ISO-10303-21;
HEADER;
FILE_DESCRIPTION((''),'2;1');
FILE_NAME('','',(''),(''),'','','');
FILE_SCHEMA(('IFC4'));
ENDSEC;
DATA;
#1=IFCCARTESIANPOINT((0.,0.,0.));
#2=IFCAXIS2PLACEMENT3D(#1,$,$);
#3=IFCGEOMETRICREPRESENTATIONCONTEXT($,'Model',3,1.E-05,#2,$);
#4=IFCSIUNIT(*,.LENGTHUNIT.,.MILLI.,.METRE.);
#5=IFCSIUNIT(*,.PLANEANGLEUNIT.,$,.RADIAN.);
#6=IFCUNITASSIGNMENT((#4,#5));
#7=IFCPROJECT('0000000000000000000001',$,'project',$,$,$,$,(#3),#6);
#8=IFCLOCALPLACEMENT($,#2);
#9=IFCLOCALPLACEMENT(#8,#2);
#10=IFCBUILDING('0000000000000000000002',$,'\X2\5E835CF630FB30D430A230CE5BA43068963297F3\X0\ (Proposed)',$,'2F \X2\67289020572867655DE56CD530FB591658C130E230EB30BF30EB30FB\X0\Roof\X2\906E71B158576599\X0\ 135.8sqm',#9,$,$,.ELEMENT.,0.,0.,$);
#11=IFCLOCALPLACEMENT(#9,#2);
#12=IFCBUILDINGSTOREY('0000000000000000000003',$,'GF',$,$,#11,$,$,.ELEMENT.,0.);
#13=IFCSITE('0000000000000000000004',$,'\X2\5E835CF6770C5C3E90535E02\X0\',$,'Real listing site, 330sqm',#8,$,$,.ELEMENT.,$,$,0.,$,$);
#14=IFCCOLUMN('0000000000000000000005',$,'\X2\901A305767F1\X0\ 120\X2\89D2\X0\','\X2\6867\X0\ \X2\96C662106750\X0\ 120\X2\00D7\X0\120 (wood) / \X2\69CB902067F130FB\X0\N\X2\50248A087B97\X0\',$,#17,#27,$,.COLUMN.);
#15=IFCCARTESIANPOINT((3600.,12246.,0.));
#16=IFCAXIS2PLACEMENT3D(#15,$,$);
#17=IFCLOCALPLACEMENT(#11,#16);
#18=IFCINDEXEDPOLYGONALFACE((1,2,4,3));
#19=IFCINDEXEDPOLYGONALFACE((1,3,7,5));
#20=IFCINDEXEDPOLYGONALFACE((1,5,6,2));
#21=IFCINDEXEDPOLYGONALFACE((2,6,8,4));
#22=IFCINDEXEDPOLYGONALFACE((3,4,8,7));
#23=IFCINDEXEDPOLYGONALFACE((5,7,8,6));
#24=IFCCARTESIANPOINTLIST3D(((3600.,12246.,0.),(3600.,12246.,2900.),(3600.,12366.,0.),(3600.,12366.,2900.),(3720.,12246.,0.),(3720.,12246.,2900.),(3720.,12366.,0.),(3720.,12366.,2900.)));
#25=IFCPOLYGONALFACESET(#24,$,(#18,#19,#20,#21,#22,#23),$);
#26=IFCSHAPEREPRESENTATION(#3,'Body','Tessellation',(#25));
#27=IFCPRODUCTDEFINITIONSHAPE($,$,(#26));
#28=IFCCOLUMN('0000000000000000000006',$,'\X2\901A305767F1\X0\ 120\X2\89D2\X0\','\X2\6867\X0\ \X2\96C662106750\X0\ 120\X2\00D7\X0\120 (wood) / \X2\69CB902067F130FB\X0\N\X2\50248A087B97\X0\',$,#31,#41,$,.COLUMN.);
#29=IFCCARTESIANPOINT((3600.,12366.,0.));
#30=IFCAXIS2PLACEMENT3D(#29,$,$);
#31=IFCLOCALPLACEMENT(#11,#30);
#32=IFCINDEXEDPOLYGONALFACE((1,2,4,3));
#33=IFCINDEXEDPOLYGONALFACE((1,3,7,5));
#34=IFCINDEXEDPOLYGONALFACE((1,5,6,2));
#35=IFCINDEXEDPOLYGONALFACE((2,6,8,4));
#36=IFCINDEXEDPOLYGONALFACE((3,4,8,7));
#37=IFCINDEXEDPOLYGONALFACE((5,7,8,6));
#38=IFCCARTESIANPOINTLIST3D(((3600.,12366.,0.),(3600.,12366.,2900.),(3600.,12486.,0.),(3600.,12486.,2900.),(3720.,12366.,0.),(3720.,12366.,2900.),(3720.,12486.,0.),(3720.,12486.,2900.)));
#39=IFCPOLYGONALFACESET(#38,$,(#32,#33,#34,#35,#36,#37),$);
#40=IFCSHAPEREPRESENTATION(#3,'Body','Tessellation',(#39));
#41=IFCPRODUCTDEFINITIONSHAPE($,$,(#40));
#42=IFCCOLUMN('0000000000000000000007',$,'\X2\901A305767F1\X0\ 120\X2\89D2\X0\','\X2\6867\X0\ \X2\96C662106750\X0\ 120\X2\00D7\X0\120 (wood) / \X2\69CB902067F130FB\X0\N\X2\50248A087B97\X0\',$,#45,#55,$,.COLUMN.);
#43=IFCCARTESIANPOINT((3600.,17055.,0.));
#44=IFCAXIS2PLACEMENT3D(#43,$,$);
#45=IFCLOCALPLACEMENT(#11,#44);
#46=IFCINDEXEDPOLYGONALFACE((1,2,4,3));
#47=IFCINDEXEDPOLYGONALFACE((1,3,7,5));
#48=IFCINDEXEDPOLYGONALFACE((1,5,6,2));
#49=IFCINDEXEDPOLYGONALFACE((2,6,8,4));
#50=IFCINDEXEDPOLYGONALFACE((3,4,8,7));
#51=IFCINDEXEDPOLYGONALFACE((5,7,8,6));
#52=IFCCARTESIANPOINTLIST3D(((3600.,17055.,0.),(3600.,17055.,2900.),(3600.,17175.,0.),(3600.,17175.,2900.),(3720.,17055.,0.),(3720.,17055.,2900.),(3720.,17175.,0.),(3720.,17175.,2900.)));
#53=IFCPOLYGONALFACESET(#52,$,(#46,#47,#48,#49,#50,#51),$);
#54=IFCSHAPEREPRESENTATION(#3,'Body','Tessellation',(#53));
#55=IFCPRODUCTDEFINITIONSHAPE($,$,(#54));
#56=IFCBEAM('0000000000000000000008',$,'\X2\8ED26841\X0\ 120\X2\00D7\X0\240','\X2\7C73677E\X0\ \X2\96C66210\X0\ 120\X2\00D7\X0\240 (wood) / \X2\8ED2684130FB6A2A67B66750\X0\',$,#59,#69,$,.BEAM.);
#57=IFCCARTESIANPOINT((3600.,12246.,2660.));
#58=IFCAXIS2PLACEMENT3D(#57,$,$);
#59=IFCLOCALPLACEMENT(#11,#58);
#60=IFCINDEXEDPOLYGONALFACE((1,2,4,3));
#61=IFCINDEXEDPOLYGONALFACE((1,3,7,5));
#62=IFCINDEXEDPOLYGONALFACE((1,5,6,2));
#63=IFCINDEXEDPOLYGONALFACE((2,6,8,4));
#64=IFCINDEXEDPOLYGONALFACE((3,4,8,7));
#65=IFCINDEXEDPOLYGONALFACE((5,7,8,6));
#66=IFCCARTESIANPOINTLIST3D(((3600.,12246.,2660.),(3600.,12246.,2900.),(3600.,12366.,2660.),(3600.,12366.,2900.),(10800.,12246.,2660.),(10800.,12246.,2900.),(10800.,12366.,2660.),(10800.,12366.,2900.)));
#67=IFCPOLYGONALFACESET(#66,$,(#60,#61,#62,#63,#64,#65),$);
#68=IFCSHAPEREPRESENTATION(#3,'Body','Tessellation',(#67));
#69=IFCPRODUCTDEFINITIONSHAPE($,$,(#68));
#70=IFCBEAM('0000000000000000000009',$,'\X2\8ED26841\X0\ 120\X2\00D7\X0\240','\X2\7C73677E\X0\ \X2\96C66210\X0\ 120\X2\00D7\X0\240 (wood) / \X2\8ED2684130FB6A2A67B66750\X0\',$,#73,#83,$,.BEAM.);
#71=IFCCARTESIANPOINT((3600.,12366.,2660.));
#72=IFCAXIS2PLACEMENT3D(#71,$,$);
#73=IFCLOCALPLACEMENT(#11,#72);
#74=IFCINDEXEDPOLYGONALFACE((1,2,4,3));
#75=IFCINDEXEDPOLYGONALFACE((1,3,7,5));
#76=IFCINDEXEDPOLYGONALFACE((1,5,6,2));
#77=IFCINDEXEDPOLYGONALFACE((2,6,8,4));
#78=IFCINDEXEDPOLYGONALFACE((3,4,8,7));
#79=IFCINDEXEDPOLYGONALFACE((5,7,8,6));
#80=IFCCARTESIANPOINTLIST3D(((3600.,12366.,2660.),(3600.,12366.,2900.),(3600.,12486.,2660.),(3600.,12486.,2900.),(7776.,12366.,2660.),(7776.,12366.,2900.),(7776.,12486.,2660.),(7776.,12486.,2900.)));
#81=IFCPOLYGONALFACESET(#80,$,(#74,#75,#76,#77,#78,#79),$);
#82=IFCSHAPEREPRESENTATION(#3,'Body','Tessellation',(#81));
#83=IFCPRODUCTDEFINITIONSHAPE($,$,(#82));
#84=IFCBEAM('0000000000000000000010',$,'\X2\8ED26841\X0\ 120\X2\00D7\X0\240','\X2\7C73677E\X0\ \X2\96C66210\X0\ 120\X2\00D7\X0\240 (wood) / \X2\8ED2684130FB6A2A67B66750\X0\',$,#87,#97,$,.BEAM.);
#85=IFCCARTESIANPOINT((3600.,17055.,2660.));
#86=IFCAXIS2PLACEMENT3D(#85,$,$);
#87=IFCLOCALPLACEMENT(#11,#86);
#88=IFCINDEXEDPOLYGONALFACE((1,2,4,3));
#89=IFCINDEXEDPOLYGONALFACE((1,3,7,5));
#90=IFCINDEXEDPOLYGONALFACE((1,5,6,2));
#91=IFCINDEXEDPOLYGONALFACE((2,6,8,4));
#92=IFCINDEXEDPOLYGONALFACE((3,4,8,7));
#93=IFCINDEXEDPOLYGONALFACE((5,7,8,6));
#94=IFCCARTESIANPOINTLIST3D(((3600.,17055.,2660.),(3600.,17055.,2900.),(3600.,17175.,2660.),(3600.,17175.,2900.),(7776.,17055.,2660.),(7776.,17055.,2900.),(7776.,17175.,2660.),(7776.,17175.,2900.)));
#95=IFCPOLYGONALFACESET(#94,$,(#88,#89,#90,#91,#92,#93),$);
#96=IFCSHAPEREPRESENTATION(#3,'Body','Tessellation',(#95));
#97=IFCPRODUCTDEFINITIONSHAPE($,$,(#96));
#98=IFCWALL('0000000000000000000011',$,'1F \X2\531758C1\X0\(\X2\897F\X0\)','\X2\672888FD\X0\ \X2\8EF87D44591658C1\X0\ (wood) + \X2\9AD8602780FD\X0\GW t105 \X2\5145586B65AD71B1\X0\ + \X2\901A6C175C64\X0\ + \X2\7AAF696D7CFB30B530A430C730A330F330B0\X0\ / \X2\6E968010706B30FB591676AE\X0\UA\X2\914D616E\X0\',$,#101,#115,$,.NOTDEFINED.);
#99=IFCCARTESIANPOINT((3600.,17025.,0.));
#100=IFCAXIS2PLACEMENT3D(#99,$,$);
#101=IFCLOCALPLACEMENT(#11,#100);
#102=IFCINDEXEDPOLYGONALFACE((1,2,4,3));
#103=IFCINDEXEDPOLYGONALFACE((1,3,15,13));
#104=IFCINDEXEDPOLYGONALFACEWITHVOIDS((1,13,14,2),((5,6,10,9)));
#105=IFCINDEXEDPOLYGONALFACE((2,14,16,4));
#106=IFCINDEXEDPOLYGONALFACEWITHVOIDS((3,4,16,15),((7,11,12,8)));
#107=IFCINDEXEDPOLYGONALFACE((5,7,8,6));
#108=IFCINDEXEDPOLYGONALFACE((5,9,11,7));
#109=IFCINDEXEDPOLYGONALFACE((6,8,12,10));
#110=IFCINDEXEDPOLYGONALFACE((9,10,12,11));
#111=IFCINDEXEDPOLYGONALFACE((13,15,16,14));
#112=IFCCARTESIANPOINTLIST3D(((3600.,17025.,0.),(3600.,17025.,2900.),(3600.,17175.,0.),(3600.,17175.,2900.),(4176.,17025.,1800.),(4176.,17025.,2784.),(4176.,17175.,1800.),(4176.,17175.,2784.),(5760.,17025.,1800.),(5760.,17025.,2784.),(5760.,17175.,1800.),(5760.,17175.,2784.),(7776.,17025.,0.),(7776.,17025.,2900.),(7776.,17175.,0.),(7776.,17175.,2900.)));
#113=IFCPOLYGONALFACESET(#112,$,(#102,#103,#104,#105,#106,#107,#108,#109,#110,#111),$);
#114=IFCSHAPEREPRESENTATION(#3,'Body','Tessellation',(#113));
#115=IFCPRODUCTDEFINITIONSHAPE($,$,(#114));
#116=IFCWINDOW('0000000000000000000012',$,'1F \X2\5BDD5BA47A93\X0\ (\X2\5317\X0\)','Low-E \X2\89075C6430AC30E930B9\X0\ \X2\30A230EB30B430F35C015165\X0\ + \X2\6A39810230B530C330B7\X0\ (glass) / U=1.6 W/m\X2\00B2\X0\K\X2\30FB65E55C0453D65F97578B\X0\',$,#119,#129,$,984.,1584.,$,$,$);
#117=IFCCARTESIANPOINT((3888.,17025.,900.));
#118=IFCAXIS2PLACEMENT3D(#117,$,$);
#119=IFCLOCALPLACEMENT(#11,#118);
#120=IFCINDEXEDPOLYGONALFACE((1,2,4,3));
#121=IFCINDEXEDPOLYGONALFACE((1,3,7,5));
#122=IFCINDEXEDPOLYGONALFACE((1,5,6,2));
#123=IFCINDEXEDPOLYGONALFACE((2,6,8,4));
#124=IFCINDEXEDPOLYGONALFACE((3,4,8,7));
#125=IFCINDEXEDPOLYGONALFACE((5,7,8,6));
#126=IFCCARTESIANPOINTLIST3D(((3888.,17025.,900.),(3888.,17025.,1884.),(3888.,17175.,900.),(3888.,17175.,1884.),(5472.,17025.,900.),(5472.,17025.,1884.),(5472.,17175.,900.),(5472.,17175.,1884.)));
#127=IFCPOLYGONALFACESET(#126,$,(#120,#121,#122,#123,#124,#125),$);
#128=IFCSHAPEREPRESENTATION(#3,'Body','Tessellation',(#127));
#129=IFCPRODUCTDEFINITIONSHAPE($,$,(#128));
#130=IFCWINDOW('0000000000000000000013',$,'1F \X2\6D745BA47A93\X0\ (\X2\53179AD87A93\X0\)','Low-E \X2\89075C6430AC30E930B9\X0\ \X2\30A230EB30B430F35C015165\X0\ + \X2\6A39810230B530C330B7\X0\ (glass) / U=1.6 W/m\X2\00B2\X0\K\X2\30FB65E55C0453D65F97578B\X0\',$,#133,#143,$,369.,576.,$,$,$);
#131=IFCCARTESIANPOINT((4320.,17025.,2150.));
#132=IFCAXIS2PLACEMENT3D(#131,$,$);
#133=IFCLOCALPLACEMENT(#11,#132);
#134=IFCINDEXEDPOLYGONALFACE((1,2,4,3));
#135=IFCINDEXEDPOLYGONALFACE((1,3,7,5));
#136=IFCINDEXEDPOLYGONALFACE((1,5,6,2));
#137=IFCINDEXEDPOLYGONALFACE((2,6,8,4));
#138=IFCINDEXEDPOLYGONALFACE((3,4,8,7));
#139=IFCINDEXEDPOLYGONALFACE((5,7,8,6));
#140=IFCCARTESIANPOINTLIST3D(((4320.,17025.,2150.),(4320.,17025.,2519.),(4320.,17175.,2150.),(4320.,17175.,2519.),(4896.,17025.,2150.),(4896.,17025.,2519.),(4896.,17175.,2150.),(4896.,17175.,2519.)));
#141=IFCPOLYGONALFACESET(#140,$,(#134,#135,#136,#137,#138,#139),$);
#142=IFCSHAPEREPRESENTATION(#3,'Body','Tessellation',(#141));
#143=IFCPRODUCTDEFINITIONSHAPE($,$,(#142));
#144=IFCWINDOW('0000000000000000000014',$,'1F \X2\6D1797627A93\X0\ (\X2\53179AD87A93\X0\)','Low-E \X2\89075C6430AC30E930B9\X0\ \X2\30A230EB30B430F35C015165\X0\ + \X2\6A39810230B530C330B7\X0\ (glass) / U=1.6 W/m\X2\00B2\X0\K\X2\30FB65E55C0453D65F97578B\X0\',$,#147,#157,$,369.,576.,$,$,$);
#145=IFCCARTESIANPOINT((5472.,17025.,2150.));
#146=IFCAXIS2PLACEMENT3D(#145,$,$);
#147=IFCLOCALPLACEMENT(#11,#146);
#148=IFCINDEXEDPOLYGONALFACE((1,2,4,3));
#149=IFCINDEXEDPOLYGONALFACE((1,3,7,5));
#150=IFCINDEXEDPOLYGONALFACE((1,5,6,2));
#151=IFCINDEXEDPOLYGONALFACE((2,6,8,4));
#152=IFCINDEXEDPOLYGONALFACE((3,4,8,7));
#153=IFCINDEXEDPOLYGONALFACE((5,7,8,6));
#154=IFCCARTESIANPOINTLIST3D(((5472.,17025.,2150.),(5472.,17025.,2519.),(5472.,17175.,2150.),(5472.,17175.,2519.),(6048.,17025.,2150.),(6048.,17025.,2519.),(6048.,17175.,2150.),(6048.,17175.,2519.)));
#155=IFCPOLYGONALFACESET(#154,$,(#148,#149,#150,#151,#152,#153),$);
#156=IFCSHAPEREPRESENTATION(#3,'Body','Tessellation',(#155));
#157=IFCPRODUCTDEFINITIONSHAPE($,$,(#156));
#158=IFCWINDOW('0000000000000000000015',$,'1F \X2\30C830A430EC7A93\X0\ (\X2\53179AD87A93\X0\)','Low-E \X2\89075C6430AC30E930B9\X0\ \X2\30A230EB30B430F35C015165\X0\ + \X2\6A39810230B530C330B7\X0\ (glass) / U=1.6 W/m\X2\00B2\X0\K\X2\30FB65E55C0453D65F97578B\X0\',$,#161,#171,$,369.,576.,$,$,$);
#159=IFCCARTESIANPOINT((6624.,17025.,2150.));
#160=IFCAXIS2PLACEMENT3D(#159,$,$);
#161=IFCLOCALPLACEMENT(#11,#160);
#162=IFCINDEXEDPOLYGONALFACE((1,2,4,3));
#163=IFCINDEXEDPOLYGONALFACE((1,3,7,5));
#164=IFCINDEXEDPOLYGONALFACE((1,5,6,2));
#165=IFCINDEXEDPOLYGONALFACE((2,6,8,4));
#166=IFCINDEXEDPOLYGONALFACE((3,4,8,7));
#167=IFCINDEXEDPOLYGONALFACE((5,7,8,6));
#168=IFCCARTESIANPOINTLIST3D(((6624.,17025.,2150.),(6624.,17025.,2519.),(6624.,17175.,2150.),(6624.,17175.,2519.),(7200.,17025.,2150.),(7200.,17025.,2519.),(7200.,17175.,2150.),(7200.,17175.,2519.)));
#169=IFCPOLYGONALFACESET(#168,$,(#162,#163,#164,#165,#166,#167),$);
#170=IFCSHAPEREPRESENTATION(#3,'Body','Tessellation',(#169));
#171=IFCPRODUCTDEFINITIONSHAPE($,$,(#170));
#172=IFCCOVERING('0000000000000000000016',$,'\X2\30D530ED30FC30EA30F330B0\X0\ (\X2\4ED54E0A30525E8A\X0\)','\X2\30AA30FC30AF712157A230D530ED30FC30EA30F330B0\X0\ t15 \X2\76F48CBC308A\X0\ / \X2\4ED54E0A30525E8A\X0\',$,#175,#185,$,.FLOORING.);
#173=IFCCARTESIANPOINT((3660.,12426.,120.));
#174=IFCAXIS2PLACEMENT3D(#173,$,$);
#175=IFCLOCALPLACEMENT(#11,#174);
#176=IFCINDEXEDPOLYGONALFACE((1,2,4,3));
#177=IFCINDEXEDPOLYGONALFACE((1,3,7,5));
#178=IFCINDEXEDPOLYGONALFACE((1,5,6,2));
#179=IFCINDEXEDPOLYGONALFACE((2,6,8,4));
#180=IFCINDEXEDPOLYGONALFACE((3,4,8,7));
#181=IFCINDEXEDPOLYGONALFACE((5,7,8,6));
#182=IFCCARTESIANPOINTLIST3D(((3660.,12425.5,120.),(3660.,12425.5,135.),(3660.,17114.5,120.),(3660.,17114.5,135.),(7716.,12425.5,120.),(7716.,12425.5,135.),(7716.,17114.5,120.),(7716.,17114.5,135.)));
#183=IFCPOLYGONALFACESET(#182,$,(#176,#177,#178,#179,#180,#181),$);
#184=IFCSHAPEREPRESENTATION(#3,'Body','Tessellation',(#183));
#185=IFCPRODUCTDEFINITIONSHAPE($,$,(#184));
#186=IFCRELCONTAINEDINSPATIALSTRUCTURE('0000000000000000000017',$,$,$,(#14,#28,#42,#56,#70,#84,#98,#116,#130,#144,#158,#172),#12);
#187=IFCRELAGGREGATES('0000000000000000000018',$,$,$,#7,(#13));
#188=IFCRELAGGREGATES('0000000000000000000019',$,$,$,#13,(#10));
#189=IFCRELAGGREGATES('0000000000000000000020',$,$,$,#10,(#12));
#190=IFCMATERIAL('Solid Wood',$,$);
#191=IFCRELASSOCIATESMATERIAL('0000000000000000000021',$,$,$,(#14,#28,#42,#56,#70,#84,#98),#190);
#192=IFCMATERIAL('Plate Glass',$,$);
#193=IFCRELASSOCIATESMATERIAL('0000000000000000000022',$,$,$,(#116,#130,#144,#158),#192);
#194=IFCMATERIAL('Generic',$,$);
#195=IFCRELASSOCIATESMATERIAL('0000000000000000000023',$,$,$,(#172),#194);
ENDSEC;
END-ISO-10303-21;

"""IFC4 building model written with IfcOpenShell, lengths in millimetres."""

from ifc_helpers import new_model, si_unit, frame, frame_2d, origin, place, context, project, spatial, rectangle, extrude, material, element, fill, save


model = new_model("IFC4")

# Units and contexts
model_context = context("Model", 3, precision=1e-05, world=origin())
ifc_project = project(units=[si_unit("LENGTHUNIT", "METRE", prefix="MILLI"), si_unit("PLANEANGLEUNIT", "RADIAN")], contexts=[model_context])

# Site, building, storey
site_placement = place(None, origin())
site = spatial("IfcSite", under=ifc_project, at=site_placement, Name="広島県尾道市", ObjectType="Real listing site, 330sqm", CompositionType="ELEMENT", RefElevation=0.0)
building_placement = place(site_placement, origin())
building = spatial("IfcBuilding", under=site, at=building_placement, Name="広島・ピアノ室と防音 (Proposed)", ObjectType="2F 木造在来工法・外壁モルタル・Roof遮熱塗料 135.8sqm", CompositionType="ELEMENT", ElevationOfRefHeight=0.0, ElevationOfTerrain=0.0)
storey_placement = place(building_placement, origin())
storey = spatial("IfcBuildingStorey", under=building, at=storey_placement, Name="GF", CompositionType="ELEMENT", Elevation=0.0)

# Columns
ifc_material_1 = material(Name="Solid Wood")
column_1_placement = place(storey_placement, frame((3600.0, 12246.0, 0.0)))
element("IfcColumn", 1, at=column_1_placement, inside=storey, material=ifc_material_1, Name="通し柱 120角", Description="桧 集成材 120×120 (wood) / 構造柱・N値計算", PredefinedType="COLUMN", context=model_context, shape_type="SweptSolid", body=[
    extrude(rectangle(XDim=120.0, YDim=120.0, at=frame_2d((60.0, 60.0))), frame((3600.0, 12246.0, 0.0)), (0.0, 0.0, 1.0), 2900.0),
])
column_2_placement = place(storey_placement, frame((3600.0, 12366.0, 0.0)))
element("IfcColumn", 2, at=column_2_placement, inside=storey, material=ifc_material_1, Name="通し柱 120角", Description="桧 集成材 120×120 (wood) / 構造柱・N値計算", PredefinedType="COLUMN", context=model_context, shape_type="SweptSolid", body=[
    extrude(rectangle(XDim=120.0, YDim=120.0, at=frame_2d((60.0, 60.0))), frame((3600.0, 12366.0, 0.0)), (0.0, 0.0, 1.0), 2900.0),
])
column_3_placement = place(storey_placement, frame((3600.0, 17055.0, 0.0)))
element("IfcColumn", 3, at=column_3_placement, inside=storey, material=ifc_material_1, Name="通し柱 120角", Description="桧 集成材 120×120 (wood) / 構造柱・N値計算", PredefinedType="COLUMN", context=model_context, shape_type="SweptSolid", body=[
    extrude(rectangle(XDim=120.0, YDim=120.0, at=frame_2d((60.0, 60.0))), frame((3600.0, 17055.0, 0.0)), (0.0, 0.0, 1.0), 2900.0),
])

# Beams
beam_1_placement = place(storey_placement, frame((3600.0, 12246.0, 2660.0)))
element("IfcBeam", 4, at=beam_1_placement, inside=storey, material=ifc_material_1, Name="軒桁 120×240", Description="米松 集成 120×240 (wood) / 軒桁・横架材", PredefinedType="BEAM", context=model_context, shape_type="SweptSolid", body=[
    extrude(rectangle(XDim=7200.0, YDim=120.0, at=frame_2d((3600.0, 60.0))), frame((3600.0, 12246.0, 2660.0)), (0.0, 0.0, 1.0), 240.0),
])
beam_2_placement = place(storey_placement, frame((3600.0, 12366.0, 2660.0)))
element("IfcBeam", 5, at=beam_2_placement, inside=storey, material=ifc_material_1, Name="軒桁 120×240", Description="米松 集成 120×240 (wood) / 軒桁・横架材", PredefinedType="BEAM", context=model_context, shape_type="SweptSolid", body=[
    extrude(rectangle(XDim=4176.0, YDim=120.0, at=frame_2d((2088.0, 60.0))), frame((3600.0, 12366.0, 2660.0)), (0.0, 0.0, 1.0), 240.0),
])
beam_3_placement = place(storey_placement, frame((3600.0, 17055.0, 2660.0)))
element("IfcBeam", 6, at=beam_3_placement, inside=storey, material=ifc_material_1, Name="軒桁 120×240", Description="米松 集成 120×240 (wood) / 軒桁・横架材", PredefinedType="BEAM", context=model_context, shape_type="SweptSolid", body=[
    extrude(rectangle(XDim=4176.0, YDim=120.0, at=frame_2d((2088.0, 60.0))), frame((3600.0, 17055.0, 2660.0)), (0.0, 0.0, 1.0), 240.0),
])

# Wall, openings, windows
wall_1_placement = place(storey_placement, frame((3600.0, 17025.0, 0.0)))
wall_1 = element("IfcWall", 7, at=wall_1_placement, inside=storey, material=ifc_material_1, Name="1F 北壁(西)", Description="木製 軸組外壁 (wood) + 高性能GW t105 充填断熱 + 通気層 + 窯業系サイディング / 準耐火・外皮UA配慮", PredefinedType="NOTDEFINED", context=model_context, shape_type="SweptSolid", body=[
    extrude(rectangle(XDim=4176.0, YDim=150.0, at=frame_2d((2088.0, 75.0))), frame((3600.0, 17025.0, 0.0)), (0.0, 0.0, 1.0), 2900.0),
])
opening_1_placement = place(storey_placement, frame((3888.0, 17025.0, 900.0)))
opening_1 = element("IfcOpeningElement", 8, at=opening_1_placement, cuts=wall_1, PredefinedType="NOTDEFINED", context=model_context, shape_type="SweptSolid", body=[
    extrude(rectangle(XDim=1584.0, YDim=150.0, at=frame_2d((792.0, 75.0))), frame((3888.0, 17025.0, 900.0)), (0.0, 0.0, 1.0), 984.0),
])
opening_2_placement = place(storey_placement, frame((4320.0, 17025.0, 2150.0)))
opening_2 = element("IfcOpeningElement", 9, at=opening_2_placement, cuts=wall_1, PredefinedType="NOTDEFINED", context=model_context, shape_type="SweptSolid", body=[
    extrude(rectangle(XDim=576.0, YDim=150.0, at=frame_2d((288.0, 75.0))), frame((4320.0, 17025.0, 2150.0)), (0.0, 0.0, 1.0), 369.0),
])
opening_3_placement = place(storey_placement, frame((5472.0, 17025.0, 2150.0)))
opening_3 = element("IfcOpeningElement", 10, at=opening_3_placement, cuts=wall_1, PredefinedType="NOTDEFINED", context=model_context, shape_type="SweptSolid", body=[
    extrude(rectangle(XDim=576.0, YDim=150.0, at=frame_2d((288.0, 75.0))), frame((5472.0, 17025.0, 2150.0)), (0.0, 0.0, 1.0), 369.0),
])
opening_4_placement = place(storey_placement, frame((6624.0, 17025.0, 2150.0)))
opening_4 = element("IfcOpeningElement", 11, at=opening_4_placement, cuts=wall_1, PredefinedType="NOTDEFINED", context=model_context, shape_type="SweptSolid", body=[
    extrude(rectangle(XDim=576.0, YDim=150.0, at=frame_2d((288.0, 75.0))), frame((6624.0, 17025.0, 2150.0)), (0.0, 0.0, 1.0), 369.0),
])
ifc_material_2 = material(Name="Plate Glass")
window_1_placement = place(storey_placement, frame((3888.0, 17025.0, 900.0)))
window_1 = element("IfcWindow", 12, at=window_1_placement, inside=storey, material=ifc_material_2, Name="1F 寝室窓 (北)", Description="Low-E 複層ガラス アルゴン封入 + 樹脂サッシ (glass) / U=1.6 W/m²K・日射取得型", OverallHeight=984.0, OverallWidth=1584.0, context=model_context, shape_type="SweptSolid", body=[
    extrude(rectangle(XDim=1584.0, YDim=150.0, at=frame_2d((792.0, 75.0))), frame((3888.0, 17025.0, 900.0)), (0.0, 0.0, 1.0), 984.0),
])
fill(opening_1, window_1)
window_2_placement = place(storey_placement, frame((4320.0, 17025.0, 2150.0)))
window_2 = element("IfcWindow", 13, at=window_2_placement, inside=storey, material=ifc_material_2, Name="1F 浴室窓 (北高窓)", Description="Low-E 複層ガラス アルゴン封入 + 樹脂サッシ (glass) / U=1.6 W/m²K・日射取得型", OverallHeight=369.0, OverallWidth=576.0, context=model_context, shape_type="SweptSolid", body=[
    extrude(rectangle(XDim=576.0, YDim=150.0, at=frame_2d((288.0, 75.0))), frame((4320.0, 17025.0, 2150.0)), (0.0, 0.0, 1.0), 369.0),
])
fill(opening_2, window_2)
window_3_placement = place(storey_placement, frame((5472.0, 17025.0, 2150.0)))
window_3 = element("IfcWindow", 14, at=window_3_placement, inside=storey, material=ifc_material_2, Name="1F 洗面窓 (北高窓)", Description="Low-E 複層ガラス アルゴン封入 + 樹脂サッシ (glass) / U=1.6 W/m²K・日射取得型", OverallHeight=369.0, OverallWidth=576.0, context=model_context, shape_type="SweptSolid", body=[
    extrude(rectangle(XDim=576.0, YDim=150.0, at=frame_2d((288.0, 75.0))), frame((5472.0, 17025.0, 2150.0)), (0.0, 0.0, 1.0), 369.0),
])
fill(opening_3, window_3)
window_4_placement = place(storey_placement, frame((6624.0, 17025.0, 2150.0)))
window_4 = element("IfcWindow", 15, at=window_4_placement, inside=storey, material=ifc_material_2, Name="1F トイレ窓 (北高窓)", Description="Low-E 複層ガラス アルゴン封入 + 樹脂サッシ (glass) / U=1.6 W/m²K・日射取得型", OverallHeight=369.0, OverallWidth=576.0, context=model_context, shape_type="SweptSolid", body=[
    extrude(rectangle(XDim=576.0, YDim=150.0, at=frame_2d((288.0, 75.0))), frame((6624.0, 17025.0, 2150.0)), (0.0, 0.0, 1.0), 369.0),
])
fill(opening_4, window_4)

# Covering
ifc_material_3 = material(Name="Generic")
covering_placement = place(storey_placement, frame((3660.0, 12426.0, 120.0)))
element("IfcCovering", 16, at=covering_placement, inside=storey, material=ifc_material_3, Name="フローリング (仕上げ床)", Description="オーク無垢フローリング t15 直貼り / 仕上げ床", PredefinedType="FLOORING", context=model_context, shape_type="SweptSolid", body=[
    extrude(rectangle(XDim=4056.0, YDim=4689.0, at=frame_2d((2028.0, 2344.0))), frame((3660.0, 12426.0, 120.0)), (0.0, 0.0, 1.0), 15.0),
])

save(model, "model.ifc")
